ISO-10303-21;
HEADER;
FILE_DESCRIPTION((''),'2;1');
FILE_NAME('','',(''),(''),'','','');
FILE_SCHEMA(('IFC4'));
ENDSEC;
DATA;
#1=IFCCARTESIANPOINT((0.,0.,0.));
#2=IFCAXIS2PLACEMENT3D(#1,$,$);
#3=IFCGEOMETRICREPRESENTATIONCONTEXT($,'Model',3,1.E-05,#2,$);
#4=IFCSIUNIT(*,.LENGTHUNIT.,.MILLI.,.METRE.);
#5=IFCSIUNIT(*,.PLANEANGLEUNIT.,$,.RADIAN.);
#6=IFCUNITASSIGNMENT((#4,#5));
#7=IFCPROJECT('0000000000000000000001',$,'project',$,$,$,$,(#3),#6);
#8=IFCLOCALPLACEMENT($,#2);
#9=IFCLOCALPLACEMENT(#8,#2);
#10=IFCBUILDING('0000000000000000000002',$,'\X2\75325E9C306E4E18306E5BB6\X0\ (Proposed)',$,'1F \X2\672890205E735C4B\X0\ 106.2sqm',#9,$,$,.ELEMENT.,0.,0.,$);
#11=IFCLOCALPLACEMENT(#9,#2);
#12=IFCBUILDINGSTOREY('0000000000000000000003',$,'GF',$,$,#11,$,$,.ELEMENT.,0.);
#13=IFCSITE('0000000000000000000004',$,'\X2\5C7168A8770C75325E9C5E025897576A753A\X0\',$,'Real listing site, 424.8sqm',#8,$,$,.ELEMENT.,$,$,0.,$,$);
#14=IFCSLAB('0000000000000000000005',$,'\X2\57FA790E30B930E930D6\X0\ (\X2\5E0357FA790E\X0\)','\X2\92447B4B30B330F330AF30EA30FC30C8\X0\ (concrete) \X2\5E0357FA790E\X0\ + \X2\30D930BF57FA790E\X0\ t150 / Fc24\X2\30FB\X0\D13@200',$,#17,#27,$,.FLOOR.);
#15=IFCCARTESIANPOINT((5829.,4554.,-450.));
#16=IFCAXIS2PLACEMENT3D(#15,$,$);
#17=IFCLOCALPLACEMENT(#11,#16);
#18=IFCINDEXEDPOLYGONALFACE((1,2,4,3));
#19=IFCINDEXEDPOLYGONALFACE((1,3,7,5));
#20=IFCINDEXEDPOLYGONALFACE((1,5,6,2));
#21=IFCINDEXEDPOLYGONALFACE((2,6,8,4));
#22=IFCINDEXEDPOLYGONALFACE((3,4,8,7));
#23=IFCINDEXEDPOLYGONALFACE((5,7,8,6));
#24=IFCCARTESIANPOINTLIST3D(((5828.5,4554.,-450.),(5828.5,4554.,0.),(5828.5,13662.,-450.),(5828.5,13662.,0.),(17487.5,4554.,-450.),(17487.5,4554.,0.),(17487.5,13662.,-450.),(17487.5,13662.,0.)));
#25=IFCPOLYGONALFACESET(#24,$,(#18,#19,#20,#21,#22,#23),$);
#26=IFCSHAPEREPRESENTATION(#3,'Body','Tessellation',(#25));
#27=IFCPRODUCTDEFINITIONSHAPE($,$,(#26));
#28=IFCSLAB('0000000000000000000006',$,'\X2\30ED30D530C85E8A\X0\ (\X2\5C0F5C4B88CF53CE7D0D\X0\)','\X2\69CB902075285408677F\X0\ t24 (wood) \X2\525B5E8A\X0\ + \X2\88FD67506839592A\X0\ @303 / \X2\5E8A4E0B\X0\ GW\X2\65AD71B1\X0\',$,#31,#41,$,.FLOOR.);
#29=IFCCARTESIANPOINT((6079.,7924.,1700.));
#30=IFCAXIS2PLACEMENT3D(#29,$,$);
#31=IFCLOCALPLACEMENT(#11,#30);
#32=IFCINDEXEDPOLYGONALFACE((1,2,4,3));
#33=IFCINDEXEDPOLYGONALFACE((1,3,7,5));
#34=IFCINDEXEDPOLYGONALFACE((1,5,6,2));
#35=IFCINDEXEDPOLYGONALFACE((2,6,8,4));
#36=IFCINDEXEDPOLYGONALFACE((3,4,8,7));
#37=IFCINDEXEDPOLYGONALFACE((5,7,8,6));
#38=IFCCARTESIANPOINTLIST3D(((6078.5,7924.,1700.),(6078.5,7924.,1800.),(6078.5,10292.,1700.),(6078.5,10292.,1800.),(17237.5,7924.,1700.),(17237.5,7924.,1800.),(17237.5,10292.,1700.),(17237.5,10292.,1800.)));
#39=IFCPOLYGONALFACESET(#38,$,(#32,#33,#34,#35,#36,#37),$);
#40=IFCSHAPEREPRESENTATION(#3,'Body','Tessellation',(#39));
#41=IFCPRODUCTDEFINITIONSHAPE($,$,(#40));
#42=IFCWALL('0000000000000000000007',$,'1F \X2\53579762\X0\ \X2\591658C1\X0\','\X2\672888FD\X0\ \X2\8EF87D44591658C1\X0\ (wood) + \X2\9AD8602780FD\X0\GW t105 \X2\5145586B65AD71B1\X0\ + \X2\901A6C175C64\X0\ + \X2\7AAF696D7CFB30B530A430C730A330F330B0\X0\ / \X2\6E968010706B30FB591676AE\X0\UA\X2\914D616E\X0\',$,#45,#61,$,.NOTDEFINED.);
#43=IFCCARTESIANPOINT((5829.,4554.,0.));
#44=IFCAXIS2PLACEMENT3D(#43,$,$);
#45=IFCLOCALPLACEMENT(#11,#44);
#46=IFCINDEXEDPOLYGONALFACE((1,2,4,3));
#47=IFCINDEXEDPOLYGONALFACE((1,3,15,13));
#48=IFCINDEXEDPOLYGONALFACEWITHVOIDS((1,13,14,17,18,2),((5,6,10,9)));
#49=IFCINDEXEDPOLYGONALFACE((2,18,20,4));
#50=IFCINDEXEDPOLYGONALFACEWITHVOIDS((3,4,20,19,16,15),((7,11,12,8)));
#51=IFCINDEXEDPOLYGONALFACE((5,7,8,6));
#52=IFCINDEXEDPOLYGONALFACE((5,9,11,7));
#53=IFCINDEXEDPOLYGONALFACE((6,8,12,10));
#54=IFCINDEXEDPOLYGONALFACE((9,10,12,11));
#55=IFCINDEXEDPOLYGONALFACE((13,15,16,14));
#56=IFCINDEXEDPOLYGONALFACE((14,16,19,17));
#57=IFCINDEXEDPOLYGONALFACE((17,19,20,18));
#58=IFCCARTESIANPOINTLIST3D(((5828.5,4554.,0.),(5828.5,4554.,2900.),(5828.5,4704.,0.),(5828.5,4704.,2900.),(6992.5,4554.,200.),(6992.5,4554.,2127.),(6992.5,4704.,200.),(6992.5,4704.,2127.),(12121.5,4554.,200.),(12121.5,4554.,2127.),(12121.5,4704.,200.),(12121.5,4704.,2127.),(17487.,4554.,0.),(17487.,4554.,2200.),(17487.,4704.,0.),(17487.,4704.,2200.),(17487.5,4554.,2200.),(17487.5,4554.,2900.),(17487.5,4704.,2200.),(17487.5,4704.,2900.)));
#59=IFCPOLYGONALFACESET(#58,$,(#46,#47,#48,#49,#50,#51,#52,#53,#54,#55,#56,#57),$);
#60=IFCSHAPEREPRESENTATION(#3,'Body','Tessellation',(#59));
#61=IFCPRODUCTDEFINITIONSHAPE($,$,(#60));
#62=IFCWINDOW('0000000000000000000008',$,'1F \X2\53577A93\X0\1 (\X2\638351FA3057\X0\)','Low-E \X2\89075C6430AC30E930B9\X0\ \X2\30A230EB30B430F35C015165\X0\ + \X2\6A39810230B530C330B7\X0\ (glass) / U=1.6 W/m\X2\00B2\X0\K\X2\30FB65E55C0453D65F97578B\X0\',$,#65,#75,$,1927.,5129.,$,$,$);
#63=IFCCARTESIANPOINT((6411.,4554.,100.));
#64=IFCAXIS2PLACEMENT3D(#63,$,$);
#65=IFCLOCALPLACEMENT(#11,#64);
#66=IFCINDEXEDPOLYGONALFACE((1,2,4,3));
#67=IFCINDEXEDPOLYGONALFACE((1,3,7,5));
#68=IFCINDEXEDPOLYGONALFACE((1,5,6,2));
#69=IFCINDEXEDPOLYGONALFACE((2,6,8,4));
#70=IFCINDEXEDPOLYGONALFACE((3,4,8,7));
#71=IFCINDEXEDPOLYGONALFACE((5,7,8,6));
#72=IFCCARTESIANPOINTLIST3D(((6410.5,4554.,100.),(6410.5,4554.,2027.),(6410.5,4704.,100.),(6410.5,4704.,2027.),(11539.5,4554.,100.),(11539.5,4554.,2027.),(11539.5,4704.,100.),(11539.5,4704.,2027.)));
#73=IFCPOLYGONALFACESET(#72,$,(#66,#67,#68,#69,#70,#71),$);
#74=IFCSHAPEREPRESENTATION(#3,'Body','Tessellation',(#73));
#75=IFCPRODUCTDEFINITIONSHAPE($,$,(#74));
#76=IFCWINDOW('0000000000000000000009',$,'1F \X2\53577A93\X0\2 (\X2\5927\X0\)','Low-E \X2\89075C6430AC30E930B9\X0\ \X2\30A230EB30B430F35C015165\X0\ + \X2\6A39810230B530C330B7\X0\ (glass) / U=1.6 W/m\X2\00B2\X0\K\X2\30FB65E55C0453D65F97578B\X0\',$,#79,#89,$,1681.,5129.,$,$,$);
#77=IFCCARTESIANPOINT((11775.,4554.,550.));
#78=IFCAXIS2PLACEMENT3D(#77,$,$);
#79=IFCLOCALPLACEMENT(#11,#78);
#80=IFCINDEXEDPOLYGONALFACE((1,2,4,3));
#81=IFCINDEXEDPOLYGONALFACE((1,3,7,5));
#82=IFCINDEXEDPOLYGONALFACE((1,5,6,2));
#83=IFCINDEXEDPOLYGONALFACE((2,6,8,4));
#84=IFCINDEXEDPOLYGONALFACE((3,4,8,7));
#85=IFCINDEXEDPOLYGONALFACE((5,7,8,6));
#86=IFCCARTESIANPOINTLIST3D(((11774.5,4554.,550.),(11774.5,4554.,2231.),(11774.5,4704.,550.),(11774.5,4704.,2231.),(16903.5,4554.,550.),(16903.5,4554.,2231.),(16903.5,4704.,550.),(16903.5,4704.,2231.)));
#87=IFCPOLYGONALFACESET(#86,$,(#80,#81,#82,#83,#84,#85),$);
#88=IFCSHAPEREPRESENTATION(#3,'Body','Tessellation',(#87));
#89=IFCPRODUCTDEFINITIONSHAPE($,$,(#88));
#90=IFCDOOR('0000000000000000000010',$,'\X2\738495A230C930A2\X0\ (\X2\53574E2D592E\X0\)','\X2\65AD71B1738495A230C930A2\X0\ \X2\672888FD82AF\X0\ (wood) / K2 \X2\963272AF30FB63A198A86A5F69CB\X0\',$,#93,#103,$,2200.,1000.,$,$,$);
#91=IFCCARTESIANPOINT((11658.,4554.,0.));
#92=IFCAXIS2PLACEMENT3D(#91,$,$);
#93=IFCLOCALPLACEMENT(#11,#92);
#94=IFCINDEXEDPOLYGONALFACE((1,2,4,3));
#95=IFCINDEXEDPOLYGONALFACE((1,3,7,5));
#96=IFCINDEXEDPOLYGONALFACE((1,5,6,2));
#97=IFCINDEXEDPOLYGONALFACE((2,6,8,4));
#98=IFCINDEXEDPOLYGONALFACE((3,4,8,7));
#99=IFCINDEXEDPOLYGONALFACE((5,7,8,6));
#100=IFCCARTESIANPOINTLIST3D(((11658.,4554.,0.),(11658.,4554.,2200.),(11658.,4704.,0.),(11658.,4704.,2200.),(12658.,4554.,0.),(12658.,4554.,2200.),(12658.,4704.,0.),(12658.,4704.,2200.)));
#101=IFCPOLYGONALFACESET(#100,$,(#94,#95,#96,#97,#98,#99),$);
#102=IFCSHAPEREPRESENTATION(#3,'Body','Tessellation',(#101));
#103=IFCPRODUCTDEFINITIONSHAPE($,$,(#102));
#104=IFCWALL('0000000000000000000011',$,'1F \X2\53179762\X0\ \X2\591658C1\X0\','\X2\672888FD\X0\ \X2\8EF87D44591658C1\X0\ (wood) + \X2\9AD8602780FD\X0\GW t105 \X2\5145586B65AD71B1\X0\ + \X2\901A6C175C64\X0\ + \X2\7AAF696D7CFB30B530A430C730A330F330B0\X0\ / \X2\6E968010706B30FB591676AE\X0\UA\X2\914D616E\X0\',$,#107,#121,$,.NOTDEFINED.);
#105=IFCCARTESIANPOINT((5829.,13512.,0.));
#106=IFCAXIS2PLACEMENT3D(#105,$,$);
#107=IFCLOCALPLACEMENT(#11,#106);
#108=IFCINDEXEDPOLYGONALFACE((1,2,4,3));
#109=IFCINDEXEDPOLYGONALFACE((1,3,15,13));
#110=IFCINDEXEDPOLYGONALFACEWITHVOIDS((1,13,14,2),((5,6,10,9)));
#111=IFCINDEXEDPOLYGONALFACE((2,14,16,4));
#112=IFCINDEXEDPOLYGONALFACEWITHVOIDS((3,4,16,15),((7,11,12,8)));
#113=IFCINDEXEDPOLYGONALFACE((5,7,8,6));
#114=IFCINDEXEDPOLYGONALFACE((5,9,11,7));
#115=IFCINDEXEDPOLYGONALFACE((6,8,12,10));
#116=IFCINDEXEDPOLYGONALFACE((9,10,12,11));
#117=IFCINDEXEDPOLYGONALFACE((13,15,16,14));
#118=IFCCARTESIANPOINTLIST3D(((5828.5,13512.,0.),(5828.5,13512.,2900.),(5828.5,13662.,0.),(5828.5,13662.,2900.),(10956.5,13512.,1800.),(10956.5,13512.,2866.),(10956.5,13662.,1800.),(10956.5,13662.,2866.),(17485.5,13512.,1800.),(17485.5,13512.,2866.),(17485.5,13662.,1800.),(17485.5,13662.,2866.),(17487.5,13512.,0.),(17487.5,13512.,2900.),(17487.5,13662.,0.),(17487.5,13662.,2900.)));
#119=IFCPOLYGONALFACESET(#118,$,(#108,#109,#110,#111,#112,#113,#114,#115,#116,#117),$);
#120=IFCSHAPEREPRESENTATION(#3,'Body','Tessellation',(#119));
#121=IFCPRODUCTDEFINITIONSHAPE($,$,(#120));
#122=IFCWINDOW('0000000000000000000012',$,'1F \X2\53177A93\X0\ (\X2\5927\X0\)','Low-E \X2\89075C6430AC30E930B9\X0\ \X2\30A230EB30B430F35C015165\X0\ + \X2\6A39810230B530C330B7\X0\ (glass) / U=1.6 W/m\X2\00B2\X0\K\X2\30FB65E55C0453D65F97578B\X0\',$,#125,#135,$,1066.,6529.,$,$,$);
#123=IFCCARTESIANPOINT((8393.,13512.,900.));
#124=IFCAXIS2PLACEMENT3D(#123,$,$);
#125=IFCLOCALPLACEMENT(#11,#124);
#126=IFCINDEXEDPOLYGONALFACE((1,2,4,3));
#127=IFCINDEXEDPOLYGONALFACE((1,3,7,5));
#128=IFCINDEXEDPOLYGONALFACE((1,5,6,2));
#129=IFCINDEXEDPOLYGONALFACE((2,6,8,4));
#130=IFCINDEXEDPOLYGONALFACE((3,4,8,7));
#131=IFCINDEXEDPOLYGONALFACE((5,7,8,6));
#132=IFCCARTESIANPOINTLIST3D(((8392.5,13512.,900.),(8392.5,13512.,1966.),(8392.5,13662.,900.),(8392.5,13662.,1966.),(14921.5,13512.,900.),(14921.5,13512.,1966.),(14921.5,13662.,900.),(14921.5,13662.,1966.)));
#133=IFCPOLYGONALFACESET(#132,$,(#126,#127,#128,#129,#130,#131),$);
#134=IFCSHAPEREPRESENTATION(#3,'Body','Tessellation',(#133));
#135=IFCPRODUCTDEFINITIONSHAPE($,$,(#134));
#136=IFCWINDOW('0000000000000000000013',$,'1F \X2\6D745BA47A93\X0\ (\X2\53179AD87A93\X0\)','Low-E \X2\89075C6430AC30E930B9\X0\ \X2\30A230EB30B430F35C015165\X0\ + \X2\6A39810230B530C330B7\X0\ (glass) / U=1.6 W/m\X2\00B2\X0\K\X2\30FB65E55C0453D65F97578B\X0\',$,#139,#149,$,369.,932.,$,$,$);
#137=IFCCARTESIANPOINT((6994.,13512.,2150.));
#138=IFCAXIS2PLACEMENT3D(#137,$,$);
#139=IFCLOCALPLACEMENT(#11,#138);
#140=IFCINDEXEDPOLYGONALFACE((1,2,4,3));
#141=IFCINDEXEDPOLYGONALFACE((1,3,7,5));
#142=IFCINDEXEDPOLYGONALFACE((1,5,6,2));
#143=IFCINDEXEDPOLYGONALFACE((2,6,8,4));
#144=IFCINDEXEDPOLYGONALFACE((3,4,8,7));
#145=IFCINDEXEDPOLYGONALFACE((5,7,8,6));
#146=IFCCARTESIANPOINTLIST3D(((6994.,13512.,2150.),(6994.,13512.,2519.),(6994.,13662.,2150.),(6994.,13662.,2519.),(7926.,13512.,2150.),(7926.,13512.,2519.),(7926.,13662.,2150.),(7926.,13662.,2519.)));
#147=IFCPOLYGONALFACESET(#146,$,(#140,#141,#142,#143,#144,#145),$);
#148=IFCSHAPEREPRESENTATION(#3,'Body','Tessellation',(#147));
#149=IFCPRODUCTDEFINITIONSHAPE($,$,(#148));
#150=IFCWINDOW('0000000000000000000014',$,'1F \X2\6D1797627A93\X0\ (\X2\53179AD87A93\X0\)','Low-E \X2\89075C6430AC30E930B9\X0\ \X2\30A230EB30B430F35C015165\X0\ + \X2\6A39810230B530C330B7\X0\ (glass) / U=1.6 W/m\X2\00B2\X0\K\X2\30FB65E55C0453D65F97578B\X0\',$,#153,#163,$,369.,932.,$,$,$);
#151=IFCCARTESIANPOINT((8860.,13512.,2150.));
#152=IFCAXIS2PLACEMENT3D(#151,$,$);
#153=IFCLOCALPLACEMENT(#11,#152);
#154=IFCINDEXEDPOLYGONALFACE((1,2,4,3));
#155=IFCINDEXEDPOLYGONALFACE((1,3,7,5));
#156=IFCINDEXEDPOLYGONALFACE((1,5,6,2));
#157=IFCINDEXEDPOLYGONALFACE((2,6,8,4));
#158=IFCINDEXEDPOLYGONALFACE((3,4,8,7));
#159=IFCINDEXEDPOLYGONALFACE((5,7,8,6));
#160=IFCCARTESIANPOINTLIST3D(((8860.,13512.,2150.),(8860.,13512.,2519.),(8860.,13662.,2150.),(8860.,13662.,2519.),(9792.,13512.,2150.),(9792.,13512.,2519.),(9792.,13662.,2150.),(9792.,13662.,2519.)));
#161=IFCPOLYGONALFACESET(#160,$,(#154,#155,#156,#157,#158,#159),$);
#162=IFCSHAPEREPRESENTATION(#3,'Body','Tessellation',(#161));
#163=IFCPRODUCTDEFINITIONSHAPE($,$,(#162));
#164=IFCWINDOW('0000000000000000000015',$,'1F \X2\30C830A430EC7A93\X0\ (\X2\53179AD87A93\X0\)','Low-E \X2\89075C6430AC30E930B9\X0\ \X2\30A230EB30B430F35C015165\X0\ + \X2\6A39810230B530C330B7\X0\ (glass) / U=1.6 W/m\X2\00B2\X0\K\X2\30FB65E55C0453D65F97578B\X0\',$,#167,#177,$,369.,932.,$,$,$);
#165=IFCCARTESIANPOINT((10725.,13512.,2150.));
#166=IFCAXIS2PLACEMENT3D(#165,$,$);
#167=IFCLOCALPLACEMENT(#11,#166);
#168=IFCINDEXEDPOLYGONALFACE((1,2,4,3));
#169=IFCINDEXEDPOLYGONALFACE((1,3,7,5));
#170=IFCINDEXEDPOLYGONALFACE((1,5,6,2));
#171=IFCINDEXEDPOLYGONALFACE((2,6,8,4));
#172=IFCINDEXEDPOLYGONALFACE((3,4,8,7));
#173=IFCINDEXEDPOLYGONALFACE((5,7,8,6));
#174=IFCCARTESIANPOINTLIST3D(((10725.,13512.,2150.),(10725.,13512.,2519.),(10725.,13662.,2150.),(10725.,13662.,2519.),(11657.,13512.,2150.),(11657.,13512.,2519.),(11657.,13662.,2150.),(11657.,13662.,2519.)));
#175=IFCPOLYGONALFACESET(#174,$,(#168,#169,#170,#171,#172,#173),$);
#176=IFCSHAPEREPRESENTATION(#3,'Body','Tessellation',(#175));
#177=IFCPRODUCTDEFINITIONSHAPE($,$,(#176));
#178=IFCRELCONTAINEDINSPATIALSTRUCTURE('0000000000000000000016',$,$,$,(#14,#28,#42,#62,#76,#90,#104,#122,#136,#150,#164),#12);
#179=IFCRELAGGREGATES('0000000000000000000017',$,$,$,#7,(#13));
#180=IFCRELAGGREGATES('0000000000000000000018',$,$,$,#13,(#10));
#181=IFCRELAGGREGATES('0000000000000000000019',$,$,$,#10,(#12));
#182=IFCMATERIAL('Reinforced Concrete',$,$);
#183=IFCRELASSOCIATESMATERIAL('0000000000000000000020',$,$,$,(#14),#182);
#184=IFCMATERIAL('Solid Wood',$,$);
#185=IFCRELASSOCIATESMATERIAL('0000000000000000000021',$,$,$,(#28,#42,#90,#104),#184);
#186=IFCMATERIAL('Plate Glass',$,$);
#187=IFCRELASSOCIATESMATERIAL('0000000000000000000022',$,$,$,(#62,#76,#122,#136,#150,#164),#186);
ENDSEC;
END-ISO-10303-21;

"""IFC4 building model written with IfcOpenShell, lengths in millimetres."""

from ifc_helpers import new_model, si_unit, frame, frame_2d, origin, place, context, project, spatial, rectangle, extrude, material, element, fill, save


model = new_model("IFC4")

# Units and contexts
model_context = context("Model", 3, precision=1e-05, world=origin())
ifc_project = project(units=[si_unit("LENGTHUNIT", "METRE", prefix="MILLI"), si_unit("PLANEANGLEUNIT", "RADIAN")], contexts=[model_context])

# Site, building, storey
site_placement = place(None, origin())
site = spatial("IfcSite", under=ifc_project, at=site_placement, Name="山梨県甲府市増坪町", ObjectType="Real listing site, 424.8sqm", CompositionType="ELEMENT", RefElevation=0.0)
building_placement = place(site_placement, origin())
building = spatial("IfcBuilding", under=site, at=building_placement, Name="甲府の丘の家 (Proposed)", ObjectType="1F 木造平屋 106.2sqm", CompositionType="ELEMENT", ElevationOfRefHeight=0.0, ElevationOfTerrain=0.0)
storey_placement = place(building_placement, origin())
storey = spatial("IfcBuildingStorey", under=building, at=storey_placement, Name="GF", CompositionType="ELEMENT", Elevation=0.0)

# Slabs
ifc_material_1 = material(Name="Reinforced Concrete")
slab_1_placement = place(storey_placement, frame((5829.0, 4554.0, -450.0)))
element("IfcSlab", 1, at=slab_1_placement, inside=storey, material=ifc_material_1, Name="基礎スラブ (布基礎)", Description="鉄筋コンクリート (concrete) 布基礎 + ベタ基礎 t150 / Fc24・D13@200", PredefinedType="FLOOR", context=model_context, shape_type="SweptSolid", body=[
    extrude(rectangle(XDim=11659.0, YDim=9108.0, at=frame_2d((5829.0, 4554.0))), frame((5829.0, 4554.0, -450.0)), (0.0, 0.0, 1.0), 450.0),
])
ifc_material_2 = material(Name="Solid Wood")
slab_2_placement = place(storey_placement, frame((6079.0, 7924.0, 1700.0)))
element("IfcSlab", 2, at=slab_2_placement, inside=storey, material=ifc_material_2, Name="ロフト床 (小屋裏収納)", Description="構造用合板 t24 (wood) 剛床 + 製材根太 @303 / 床下 GW断熱", PredefinedType="FLOOR", context=model_context, shape_type="SweptSolid", body=[
    extrude(rectangle(XDim=11159.0, YDim=2368.0, at=frame_2d((5579.0, 1184.0))), frame((6079.0, 7924.0, 1700.0)), (0.0, 0.0, 1.0), 100.0),
])

# Wall, openings, windows, door
wall_1_placement = place(storey_placement, frame((5829.0, 4554.0, 0.0)))
wall_1 = element("IfcWall", 3, at=wall_1_placement, inside=storey, material=ifc_material_2, Name="1F 南面 外壁", Description="木製 軸組外壁 (wood) + 高性能GW t105 充填断熱 + 通気層 + 窯業系サイディング / 準耐火・外皮UA配慮", PredefinedType="NOTDEFINED", context=model_context, shape_type="SweptSolid", body=[
    extrude(rectangle(XDim=11659.0, YDim=150.0, at=frame_2d((5829.0, 75.0))), frame((5829.0, 4554.0, 0.0)), (0.0, 0.0, 1.0), 2900.0),
])
opening_1_placement = place(storey_placement, frame((6411.0, 4554.0, 100.0)))
opening_1 = element("IfcOpeningElement", 4, at=opening_1_placement, cuts=wall_1, PredefinedType="NOTDEFINED", context=model_context, shape_type="SweptSolid", body=[
    extrude(rectangle(XDim=5129.0, YDim=150.0, at=frame_2d((2564.0, 75.0))), frame((6411.0, 4554.0, 100.0)), (0.0, 0.0, 1.0), 1927.0),
])
opening_2_placement = place(storey_placement, frame((11775.0, 4554.0, 550.0)))
opening_2 = element("IfcOpeningElement", 5, at=opening_2_placement, cuts=wall_1, PredefinedType="NOTDEFINED", context=model_context, shape_type="SweptSolid", body=[
    extrude(rectangle(XDim=5129.0, YDim=150.0, at=frame_2d((2564.0, 75.0))), frame((11775.0, 4554.0, 550.0)), (0.0, 0.0, 1.0), 1681.0),
])
opening_3_placement = place(storey_placement, frame((11658.0, 4554.0, 0.0)))
opening_3 = element("IfcOpeningElement", 6, at=opening_3_placement, cuts=wall_1, PredefinedType="NOTDEFINED", context=model_context, shape_type="SweptSolid", body=[
    extrude(rectangle(XDim=1000.0, YDim=150.0, at=frame_2d((500.0, 75.0))), frame((11658.0, 4554.0, 0.0)), (0.0, 0.0, 1.0), 2200.0),
])
ifc_material_3 = material(Name="Plate Glass")
window_1_placement = place(storey_placement, frame((6411.0, 4554.0, 100.0)))
window_1 = element("IfcWindow", 7, at=window_1_placement, inside=storey, material=ifc_material_3, Name="1F 南窓1 (掃出し)", Description="Low-E 複層ガラス アルゴン封入 + 樹脂サッシ (glass) / U=1.6 W/m²K・日射取得型", OverallHeight=1927.0, OverallWidth=5129.0, context=model_context, shape_type="SweptSolid", body=[
    extrude(rectangle(XDim=5129.0, YDim=150.0, at=frame_2d((2564.0, 75.0))), frame((6411.0, 4554.0, 100.0)), (0.0, 0.0, 1.0), 1927.0),
])
fill(opening_1, window_1)
window_2_placement = place(storey_placement, frame((11775.0, 4554.0, 550.0)))
window_2 = element("IfcWindow", 8, at=window_2_placement, inside=storey, material=ifc_material_3, Name="1F 南窓2 (大)", Description="Low-E 複層ガラス アルゴン封入 + 樹脂サッシ (glass) / U=1.6 W/m²K・日射取得型", OverallHeight=1681.0, OverallWidth=5129.0, context=model_context, shape_type="SweptSolid", body=[
    extrude(rectangle(XDim=5129.0, YDim=150.0, at=frame_2d((2564.0, 75.0))), frame((11775.0, 4554.0, 550.0)), (0.0, 0.0, 1.0), 1681.0),
])
fill(opening_2, window_2)
door_1_placement = place(storey_placement, frame((11658.0, 4554.0, 0.0)))
door_1 = element("IfcDoor", 9, at=door_1_placement, inside=storey, material=ifc_material_2, Name="玄関ドア (南中央)", Description="断熱玄関ドア 木製芯 (wood) / K2 防犯・採風機構", OverallHeight=2200.0, OverallWidth=1000.0, context=model_context, shape_type="SweptSolid", body=[
    extrude(rectangle(XDim=1000.0, YDim=150.0, at=frame_2d((500.0, 75.0))), frame((11658.0, 4554.0, 0.0)), (0.0, 0.0, 1.0), 2200.0),
])
fill(opening_3, door_1)

# Wall, openings, windows
wall_2_placement = place(storey_placement, frame((5829.0, 13512.0, 0.0)))
wall_2 = element("IfcWall", 10, at=wall_2_placement, inside=storey, material=ifc_material_2, Name="1F 北面 外壁", Description="木製 軸組外壁 (wood) + 高性能GW t105 充填断熱 + 通気層 + 窯業系サイディング / 準耐火・外皮UA配慮", PredefinedType="NOTDEFINED", context=model_context, shape_type="SweptSolid", body=[
    extrude(rectangle(XDim=11659.0, YDim=150.0, at=frame_2d((5829.0, 75.0))), frame((5829.0, 13512.0, 0.0)), (0.0, 0.0, 1.0), 2900.0),
])
opening_4_placement = place(storey_placement, frame((8393.0, 13512.0, 900.0)))
opening_4 = element("IfcOpeningElement", 11, at=opening_4_placement, cuts=wall_2, PredefinedType="NOTDEFINED", context=model_context, shape_type="SweptSolid", body=[
    extrude(rectangle(XDim=6529.0, YDim=150.0, at=frame_2d((3264.0, 75.0))), frame((8393.0, 13512.0, 900.0)), (0.0, 0.0, 1.0), 1066.0),
])
opening_5_placement = place(storey_placement, frame((6994.0, 13512.0, 2150.0)))
opening_5 = element("IfcOpeningElement", 12, at=opening_5_placement, cuts=wall_2, PredefinedType="NOTDEFINED", context=model_context, shape_type="SweptSolid", body=[
    extrude(rectangle(XDim=932.0, YDim=150.0, at=frame_2d((466.0, 75.0))), frame((6994.0, 13512.0, 2150.0)), (0.0, 0.0, 1.0), 369.0),
])
opening_6_placement = place(storey_placement, frame((8860.0, 13512.0, 2150.0)))
opening_6 = element("IfcOpeningElement", 13, at=opening_6_placement, cuts=wall_2, PredefinedType="NOTDEFINED", context=model_context, shape_type="SweptSolid", body=[
    extrude(rectangle(XDim=932.0, YDim=150.0, at=frame_2d((466.0, 75.0))), frame((8860.0, 13512.0, 2150.0)), (0.0, 0.0, 1.0), 369.0),
])
opening_7_placement = place(storey_placement, frame((10725.0, 13512.0, 2150.0)))
opening_7 = element("IfcOpeningElement", 14, at=opening_7_placement, cuts=wall_2, PredefinedType="NOTDEFINED", context=model_context, shape_type="SweptSolid", body=[
    extrude(rectangle(XDim=932.0, YDim=150.0, at=frame_2d((466.0, 75.0))), frame((10725.0, 13512.0, 2150.0)), (0.0, 0.0, 1.0), 369.0),
])
window_3_placement = place(storey_placement, frame((8393.0, 13512.0, 900.0)))
window_3 = element("IfcWindow", 15, at=window_3_placement, inside=storey, material=ifc_material_3, Name="1F 北窓 (大)", Description="Low-E 複層ガラス アルゴン封入 + 樹脂サッシ (glass) / U=1.6 W/m²K・日射取得型", OverallHeight=1066.0, OverallWidth=6529.0, context=model_context, shape_type="SweptSolid", body=[
    extrude(rectangle(XDim=6529.0, YDim=150.0, at=frame_2d((3264.0, 75.0))), frame((8393.0, 13512.0, 900.0)), (0.0, 0.0, 1.0), 1066.0),
])
fill(opening_4, window_3)
window_4_placement = place(storey_placement, frame((6994.0, 13512.0, 2150.0)))
window_4 = element("IfcWindow", 16, at=window_4_placement, inside=storey, material=ifc_material_3, Name="1F 浴室窓 (北高窓)", Description="Low-E 複層ガラス アルゴン封入 + 樹脂サッシ (glass) / U=1.6 W/m²K・日射取得型", OverallHeight=369.0, OverallWidth=932.0, context=model_context, shape_type="SweptSolid", body=[
    extrude(rectangle(XDim=932.0, YDim=150.0, at=frame_2d((466.0, 75.0))), frame((6994.0, 13512.0, 2150.0)), (0.0, 0.0, 1.0), 369.0),
])
fill(opening_5, window_4)
window_5_placement = place(storey_placement, frame((8860.0, 13512.0, 2150.0)))
window_5 = element("IfcWindow", 17, at=window_5_placement, inside=storey, material=ifc_material_3, Name="1F 洗面窓 (北高窓)", Description="Low-E 複層ガラス アルゴン封入 + 樹脂サッシ (glass) / U=1.6 W/m²K・日射取得型", OverallHeight=369.0, OverallWidth=932.0, context=model_context, shape_type="SweptSolid", body=[
    extrude(rectangle(XDim=932.0, YDim=150.0, at=frame_2d((466.0, 75.0))), frame((8860.0, 13512.0, 2150.0)), (0.0, 0.0, 1.0), 369.0),
])
fill(opening_6, window_5)
window_6_placement = place(storey_placement, frame((10725.0, 13512.0, 2150.0)))
window_6 = element("IfcWindow", 18, at=window_6_placement, inside=storey, material=ifc_material_3, Name="1F トイレ窓 (北高窓)", Description="Low-E 複層ガラス アルゴン封入 + 樹脂サッシ (glass) / U=1.6 W/m²K・日射取得型", OverallHeight=369.0, OverallWidth=932.0, context=model_context, shape_type="SweptSolid", body=[
    extrude(rectangle(XDim=932.0, YDim=150.0, at=frame_2d((466.0, 75.0))), frame((10725.0, 13512.0, 2150.0)), (0.0, 0.0, 1.0), 369.0),
])
fill(opening_7, window_6)

save(model, "model.ifc")
